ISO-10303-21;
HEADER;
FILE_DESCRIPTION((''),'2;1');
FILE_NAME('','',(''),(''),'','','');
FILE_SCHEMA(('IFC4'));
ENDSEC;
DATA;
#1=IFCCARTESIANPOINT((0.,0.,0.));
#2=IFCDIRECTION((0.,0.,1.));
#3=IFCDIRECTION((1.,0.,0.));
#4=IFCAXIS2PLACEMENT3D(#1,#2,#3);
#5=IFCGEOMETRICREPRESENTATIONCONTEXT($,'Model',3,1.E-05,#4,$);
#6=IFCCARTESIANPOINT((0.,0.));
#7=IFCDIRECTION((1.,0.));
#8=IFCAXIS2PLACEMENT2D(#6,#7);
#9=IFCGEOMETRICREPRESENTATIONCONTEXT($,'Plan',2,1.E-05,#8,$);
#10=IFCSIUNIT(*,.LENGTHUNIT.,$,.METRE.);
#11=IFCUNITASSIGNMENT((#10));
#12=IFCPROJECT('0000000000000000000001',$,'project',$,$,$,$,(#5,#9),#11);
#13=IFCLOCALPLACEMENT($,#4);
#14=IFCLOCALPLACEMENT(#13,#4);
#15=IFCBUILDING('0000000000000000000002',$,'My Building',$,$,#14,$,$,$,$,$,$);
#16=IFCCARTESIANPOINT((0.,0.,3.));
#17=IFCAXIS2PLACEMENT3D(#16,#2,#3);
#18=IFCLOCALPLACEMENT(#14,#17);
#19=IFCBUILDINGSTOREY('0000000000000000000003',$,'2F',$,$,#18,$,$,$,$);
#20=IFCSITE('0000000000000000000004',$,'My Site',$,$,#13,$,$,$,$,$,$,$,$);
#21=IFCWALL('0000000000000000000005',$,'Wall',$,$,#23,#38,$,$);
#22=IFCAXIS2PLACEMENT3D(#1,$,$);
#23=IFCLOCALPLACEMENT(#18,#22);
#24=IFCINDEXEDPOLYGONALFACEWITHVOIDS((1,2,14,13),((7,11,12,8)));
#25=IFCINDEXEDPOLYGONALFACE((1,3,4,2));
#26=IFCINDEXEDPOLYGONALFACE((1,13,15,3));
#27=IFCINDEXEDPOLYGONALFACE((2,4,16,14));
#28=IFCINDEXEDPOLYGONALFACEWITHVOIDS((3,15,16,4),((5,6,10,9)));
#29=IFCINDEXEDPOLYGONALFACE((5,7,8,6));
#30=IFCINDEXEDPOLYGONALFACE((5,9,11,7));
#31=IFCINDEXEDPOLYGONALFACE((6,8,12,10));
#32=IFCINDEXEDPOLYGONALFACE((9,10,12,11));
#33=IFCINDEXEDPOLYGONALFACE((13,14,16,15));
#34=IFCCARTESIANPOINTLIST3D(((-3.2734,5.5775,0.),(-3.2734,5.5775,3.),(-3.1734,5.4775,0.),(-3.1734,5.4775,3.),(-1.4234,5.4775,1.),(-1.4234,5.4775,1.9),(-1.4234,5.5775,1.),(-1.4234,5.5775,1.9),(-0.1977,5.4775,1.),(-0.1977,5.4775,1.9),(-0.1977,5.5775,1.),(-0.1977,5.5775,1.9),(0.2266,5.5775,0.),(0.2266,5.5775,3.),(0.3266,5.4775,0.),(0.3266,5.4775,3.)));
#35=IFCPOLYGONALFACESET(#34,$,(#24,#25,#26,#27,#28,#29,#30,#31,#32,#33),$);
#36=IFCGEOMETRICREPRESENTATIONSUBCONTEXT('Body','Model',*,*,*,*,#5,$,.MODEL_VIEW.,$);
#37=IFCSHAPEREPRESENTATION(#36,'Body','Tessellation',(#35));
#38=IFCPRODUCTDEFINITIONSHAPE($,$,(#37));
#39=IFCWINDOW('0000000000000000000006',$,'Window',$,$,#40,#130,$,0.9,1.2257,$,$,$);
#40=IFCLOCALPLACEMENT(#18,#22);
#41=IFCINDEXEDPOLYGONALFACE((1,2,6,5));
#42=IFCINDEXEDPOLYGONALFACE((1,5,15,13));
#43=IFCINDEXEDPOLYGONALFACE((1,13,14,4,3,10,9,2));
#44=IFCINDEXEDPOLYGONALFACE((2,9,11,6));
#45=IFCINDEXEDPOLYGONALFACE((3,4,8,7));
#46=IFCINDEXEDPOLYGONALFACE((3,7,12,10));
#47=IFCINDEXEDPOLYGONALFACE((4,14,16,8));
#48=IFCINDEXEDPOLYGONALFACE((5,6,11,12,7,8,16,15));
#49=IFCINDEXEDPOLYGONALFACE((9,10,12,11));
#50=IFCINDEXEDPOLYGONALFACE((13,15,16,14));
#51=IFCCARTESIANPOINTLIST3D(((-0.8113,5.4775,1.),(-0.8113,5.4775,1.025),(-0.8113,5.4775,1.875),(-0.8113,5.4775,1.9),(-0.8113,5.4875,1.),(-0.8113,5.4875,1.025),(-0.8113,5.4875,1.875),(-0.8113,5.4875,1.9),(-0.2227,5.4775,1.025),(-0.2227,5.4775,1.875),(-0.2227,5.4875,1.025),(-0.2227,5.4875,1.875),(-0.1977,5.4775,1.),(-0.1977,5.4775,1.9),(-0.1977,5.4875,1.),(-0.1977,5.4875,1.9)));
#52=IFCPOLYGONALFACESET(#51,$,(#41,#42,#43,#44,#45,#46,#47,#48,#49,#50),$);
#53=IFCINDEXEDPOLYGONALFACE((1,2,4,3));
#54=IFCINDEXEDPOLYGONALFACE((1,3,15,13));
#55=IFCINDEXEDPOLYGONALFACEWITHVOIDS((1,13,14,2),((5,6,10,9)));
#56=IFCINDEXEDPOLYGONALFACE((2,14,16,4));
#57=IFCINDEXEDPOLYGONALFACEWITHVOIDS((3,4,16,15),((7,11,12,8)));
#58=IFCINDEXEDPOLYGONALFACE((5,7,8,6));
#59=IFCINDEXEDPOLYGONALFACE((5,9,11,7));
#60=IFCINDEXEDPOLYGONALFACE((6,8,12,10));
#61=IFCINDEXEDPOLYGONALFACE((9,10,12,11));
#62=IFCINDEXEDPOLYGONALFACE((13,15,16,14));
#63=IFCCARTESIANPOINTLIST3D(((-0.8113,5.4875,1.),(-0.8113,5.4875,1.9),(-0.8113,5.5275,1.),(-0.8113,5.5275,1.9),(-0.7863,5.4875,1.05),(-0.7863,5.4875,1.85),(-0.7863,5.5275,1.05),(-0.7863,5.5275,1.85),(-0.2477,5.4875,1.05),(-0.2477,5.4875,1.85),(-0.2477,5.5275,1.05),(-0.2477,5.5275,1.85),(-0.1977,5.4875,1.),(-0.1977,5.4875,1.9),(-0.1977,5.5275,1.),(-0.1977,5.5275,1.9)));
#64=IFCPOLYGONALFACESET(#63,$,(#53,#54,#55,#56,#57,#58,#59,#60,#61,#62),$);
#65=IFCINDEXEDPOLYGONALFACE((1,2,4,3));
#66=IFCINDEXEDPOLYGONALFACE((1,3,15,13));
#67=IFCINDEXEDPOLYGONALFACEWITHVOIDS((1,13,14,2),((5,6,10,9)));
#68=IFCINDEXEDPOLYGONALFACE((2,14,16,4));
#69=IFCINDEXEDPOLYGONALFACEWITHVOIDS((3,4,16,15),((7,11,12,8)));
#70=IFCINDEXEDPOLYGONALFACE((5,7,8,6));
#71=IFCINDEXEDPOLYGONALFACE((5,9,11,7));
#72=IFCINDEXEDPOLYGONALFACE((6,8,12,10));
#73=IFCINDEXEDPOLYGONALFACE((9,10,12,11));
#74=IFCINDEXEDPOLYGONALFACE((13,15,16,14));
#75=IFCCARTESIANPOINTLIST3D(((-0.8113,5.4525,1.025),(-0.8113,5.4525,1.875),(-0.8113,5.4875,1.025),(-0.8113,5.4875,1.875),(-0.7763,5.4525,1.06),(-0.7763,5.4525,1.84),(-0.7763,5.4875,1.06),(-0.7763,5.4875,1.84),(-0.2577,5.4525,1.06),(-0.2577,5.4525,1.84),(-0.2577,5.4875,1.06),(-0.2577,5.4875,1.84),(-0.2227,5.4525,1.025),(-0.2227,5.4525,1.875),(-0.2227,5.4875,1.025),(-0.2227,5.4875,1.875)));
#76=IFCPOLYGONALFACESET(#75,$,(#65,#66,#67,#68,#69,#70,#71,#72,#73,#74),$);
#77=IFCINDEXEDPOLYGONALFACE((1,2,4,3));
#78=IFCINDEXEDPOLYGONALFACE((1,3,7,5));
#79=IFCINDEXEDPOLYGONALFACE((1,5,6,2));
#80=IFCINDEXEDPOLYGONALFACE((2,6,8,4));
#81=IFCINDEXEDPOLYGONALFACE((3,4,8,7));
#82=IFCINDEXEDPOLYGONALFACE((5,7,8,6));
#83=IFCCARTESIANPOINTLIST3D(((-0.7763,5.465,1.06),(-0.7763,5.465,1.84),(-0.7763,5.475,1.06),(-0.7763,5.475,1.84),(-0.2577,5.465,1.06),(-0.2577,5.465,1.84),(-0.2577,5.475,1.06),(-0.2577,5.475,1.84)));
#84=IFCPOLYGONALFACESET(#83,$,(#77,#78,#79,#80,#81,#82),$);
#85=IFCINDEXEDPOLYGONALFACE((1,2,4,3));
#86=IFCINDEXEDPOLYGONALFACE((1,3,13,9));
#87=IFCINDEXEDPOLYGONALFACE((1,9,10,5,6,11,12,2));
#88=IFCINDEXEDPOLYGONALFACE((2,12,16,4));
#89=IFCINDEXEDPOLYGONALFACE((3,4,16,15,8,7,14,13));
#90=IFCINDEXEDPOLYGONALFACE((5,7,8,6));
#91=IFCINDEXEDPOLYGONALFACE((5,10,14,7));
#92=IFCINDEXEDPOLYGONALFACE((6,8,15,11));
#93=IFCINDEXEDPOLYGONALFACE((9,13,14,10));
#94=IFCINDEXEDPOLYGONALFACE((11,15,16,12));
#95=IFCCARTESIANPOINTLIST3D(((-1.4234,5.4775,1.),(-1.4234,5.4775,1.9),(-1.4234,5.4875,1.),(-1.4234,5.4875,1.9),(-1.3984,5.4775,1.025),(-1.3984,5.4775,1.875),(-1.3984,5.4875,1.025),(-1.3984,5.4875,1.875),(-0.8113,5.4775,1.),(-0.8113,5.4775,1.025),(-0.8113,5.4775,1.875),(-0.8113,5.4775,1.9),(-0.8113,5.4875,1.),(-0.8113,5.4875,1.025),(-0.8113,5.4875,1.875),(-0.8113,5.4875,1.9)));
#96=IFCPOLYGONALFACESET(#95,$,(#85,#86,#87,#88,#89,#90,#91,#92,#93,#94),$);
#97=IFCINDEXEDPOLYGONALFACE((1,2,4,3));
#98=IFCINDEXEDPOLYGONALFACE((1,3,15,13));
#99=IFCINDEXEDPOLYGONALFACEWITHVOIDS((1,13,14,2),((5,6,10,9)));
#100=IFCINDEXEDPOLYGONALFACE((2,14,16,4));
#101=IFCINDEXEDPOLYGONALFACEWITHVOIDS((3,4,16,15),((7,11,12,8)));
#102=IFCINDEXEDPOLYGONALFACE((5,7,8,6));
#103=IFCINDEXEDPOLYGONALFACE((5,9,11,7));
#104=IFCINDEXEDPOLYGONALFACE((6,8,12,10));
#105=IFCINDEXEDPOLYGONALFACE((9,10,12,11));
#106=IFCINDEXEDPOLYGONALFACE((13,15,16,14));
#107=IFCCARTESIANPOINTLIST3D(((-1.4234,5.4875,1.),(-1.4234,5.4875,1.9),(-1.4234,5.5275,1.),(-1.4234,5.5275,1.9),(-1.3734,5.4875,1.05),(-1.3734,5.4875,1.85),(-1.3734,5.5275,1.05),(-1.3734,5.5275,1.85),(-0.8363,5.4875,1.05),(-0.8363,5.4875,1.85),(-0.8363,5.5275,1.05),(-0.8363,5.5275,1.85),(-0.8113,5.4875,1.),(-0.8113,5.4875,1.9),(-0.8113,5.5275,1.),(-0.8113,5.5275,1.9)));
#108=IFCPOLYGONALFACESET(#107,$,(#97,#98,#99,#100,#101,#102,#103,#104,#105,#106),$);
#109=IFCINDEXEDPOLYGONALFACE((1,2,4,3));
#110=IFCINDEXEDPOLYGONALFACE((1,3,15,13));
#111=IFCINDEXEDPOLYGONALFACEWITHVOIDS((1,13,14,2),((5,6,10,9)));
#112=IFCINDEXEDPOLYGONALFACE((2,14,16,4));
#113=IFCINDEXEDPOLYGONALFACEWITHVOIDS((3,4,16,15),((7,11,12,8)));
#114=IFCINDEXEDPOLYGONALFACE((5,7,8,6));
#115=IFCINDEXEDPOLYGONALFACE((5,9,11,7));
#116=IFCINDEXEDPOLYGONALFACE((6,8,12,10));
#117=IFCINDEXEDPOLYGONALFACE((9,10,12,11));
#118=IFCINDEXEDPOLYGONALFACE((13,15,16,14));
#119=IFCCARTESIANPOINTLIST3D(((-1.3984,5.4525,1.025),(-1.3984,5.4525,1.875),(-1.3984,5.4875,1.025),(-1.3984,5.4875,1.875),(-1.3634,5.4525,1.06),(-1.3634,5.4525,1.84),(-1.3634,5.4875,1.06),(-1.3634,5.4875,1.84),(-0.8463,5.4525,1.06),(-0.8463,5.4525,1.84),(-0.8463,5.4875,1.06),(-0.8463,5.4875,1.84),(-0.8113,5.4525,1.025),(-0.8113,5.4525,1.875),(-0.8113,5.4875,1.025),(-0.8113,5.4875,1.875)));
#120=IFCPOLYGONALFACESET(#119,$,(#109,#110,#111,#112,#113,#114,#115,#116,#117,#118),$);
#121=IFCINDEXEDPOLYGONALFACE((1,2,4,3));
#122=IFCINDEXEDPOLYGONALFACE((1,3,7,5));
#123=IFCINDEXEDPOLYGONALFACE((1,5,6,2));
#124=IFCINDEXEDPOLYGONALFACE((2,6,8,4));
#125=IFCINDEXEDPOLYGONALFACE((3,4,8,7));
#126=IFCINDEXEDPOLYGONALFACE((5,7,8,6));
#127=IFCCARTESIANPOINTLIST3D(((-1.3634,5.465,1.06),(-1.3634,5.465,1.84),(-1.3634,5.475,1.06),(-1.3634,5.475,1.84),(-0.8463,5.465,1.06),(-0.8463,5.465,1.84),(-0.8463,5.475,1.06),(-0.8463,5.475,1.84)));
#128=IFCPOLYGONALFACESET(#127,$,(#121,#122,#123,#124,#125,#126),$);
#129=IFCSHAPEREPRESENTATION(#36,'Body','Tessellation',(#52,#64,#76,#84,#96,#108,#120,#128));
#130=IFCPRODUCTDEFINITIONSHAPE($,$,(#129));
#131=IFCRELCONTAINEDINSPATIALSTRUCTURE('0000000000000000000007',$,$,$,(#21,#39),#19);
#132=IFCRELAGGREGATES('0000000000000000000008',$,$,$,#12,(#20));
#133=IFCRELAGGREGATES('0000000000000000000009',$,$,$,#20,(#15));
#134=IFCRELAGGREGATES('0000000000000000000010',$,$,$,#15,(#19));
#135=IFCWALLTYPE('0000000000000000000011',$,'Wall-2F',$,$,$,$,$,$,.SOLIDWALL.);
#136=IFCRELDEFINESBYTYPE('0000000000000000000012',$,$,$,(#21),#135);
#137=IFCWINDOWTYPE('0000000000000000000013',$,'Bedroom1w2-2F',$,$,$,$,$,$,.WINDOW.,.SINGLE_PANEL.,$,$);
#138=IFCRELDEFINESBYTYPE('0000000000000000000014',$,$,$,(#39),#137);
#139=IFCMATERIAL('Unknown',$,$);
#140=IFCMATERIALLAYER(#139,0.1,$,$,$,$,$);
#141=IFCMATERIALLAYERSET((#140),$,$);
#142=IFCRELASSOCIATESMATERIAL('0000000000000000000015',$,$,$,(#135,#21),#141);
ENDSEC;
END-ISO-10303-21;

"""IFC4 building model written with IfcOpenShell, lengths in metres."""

from ifc_helpers import new_model, entity, si_unit, frame, origin_with_axes, origin_2d_with_axis, place, context, subcontext, project, spatial, line, indexed_curve, outline, extrude, shape, source, transform, mapped, material, layer, layer_set, layer_usage, type_object, type_shapes, element, fill, save


model = new_model("IFC4")

# Units and contexts
model_context = context("Model", 3, precision=1e-05, world=origin_with_axes())
plan_context = context("Plan", 2, precision=1e-05, world=origin_2d_with_axis())
body_context_1 = subcontext(model_context, "Body", "Model", "MODEL_VIEW")
body_context_2 = subcontext(plan_context, "Body", "Plan", "PLAN_VIEW")
ifc_project = project(units=[si_unit("LENGTHUNIT", "METRE")], contexts=[model_context, plan_context])

# Site, building, storey
site_placement = place(None, origin_with_axes())
site = spatial("IfcSite", under=ifc_project, at=site_placement, Name="My Site")
building_placement = place(site_placement, origin_with_axes())
building = spatial("IfcBuilding", under=site, at=building_placement, Name="My Building")
storey_placement = place(building_placement, frame((0.0, 0.0, 3.0), z_axis=(0.0, 0.0, 1.0), x_axis=(1.0, 0.0, 0.0)))
storey = spatial("IfcBuildingStorey", under=building, at=storey_placement, Name="2F")

# Shared definitions
ifc_material = material(Name="Unknown")

# Shared definitions
ifc_layer_1 = layer(ifc_material, 0.1)
ifc_layer_set_1 = layer_set([ifc_layer_1])
wall_type_1 = type_object("IfcWallType", Name="Wall-2F", PredefinedType="SOLIDWALL", material=ifc_layer_set_1)

# Wall, opening, window
ifc_layer_usage_1 = layer_usage(ifc_layer_set_1, "AXIS2", "POSITIVE", 0.0)
wall_1_placement = place(storey_placement, frame((0.2266, 5.5775, 0.0), z_axis=(0.0, 0.0, 1.0), x_axis=(-1.0, 0.0, 0.0)))
wall_1 = element("IfcWall", 1, at=wall_1_placement, inside=storey, type_object=wall_type_1, material=ifc_layer_usage_1, Name="Wall", context=body_context_1, shape_type="SweptSolid", body=[
    extrude(outline(indexed_curve([(0.0, 0.0), (-0.1, 0.1), (3.4, 0.1), (3.5, 0.0)], segments=[line(1, 2, 3, 4, 1)])), origin_with_axes(), (0.0, 0.0, 1.0), 3.0),
])
shared_shape_1 = source(origin_with_axes(), body_context_1, "Body", "SweptSolid", [
    extrude(outline(indexed_curve([(0.0, 0.0), (1.2257, 0.0), (1.2257, 0.9), (0.0, 0.9)], segments=[line(1, 2, 3, 4, 1)])), frame((0.0, -0.6, 0.0), z_axis=(0.0, -1.0, 0.0), x_axis=(1.0, 0.0, 0.0)), (0.0, 0.0, -1.0), 1.2),
])
opening_1_placement = place(wall_1_placement, frame((0.4243, 0.0, 1.0), z_axis=(0.0, 0.0, 1.0), x_axis=(1.0, 0.0, 0.0)))
opening_1 = element("IfcOpeningElement", 2, at=opening_1_placement, cuts=wall_1, PredefinedType="OPENING", context=body_context_1, shape_type="MappedRepresentation", body=[
    mapped(shared_shape_1, transform((0.0, 0.0, 0.0), x_axis=(1.0, 0.0, 0.0), y_axis=(0.0, 1.0, 0.0), z_axis=(0.0, 0.0, 1.0), scale=1.0)),
])
window_type_1 = type_object("IfcWindowType", Name="Bedroom1w2-2F", PartitioningType="SINGLE_PANEL", PredefinedType="WINDOW")
shared_shape_2 = source(origin_with_axes(), body_context_1, "Body", "SweptSolid", [
    extrude(outline(indexed_curve([(0.6136, 0.0), (0.0, 0.0), (0.0, 0.9), (0.6136, 0.9), (0.6136, 0.875), (0.025, 0.875), (0.025, 0.025), (0.6136, 0.025)], segments=[line(1, 2, 3, 4, 5, 6, 7, 8, 1)])), frame((0.0, 0.09, 0.0), z_axis=(0.0, -1.0, 0.0), x_axis=(1.0, 0.0, 0.0)), (0.0, 0.0, -1.0), 0.01),
    extrude(outline(indexed_curve([(0.0, 0.0), (0.6136, 0.0), (0.6136, 0.9), (0.0, 0.9)], segments=[line(1, 2, 3, 4, 1)]), holes=[indexed_curve([(0.05, 0.05), (0.5886, 0.05), (0.5886, 0.85), (0.05, 0.85)], segments=[line(1, 2, 3, 4, 1)])]), frame((0.0, 0.05, 0.0), z_axis=(0.0, -1.0, 0.0), x_axis=(1.0, 0.0, 0.0)), (0.0, 0.0, -1.0), 0.04),
    extrude(outline(indexed_curve([(0.0, 0.0), (0.5886, 0.0), (0.5886, 0.85), (0.0, 0.85)], segments=[line(1, 2, 3, 4, 1)]), holes=[indexed_curve([(0.035, 0.035), (0.5536, 0.035), (0.5536, 0.815), (0.035, 0.815)], segments=[line(1, 2, 3, 4, 1)])]), frame((0.025, 0.09, 0.025), z_axis=(0.0, -1.0, 0.0), x_axis=(1.0, 0.0, 0.0)), (0.0, 0.0, -1.0), 0.035),
    extrude(outline(indexed_curve([(0.035, 0.035), (0.5536, 0.035), (0.5536, 0.815), (0.035, 0.815)], segments=[line(1, 2, 3, 4, 1)])), frame((0.025, 0.1025, 0.025), z_axis=(0.0, -1.0, 0.0), x_axis=(1.0, 0.0, 0.0)), (0.0, 0.0, -1.0), 0.01),
    extrude(outline(indexed_curve([(0.0, 0.9), (0.6121, 0.9), (0.6121, 0.0), (0.0, 0.0), (0.0, 0.025), (0.5871, 0.025), (0.5871, 0.875), (0.0, 0.875)], segments=[line(1, 2, 3, 4, 5, 6, 7, 8, 1)])), frame((0.6136, 0.09, 0.0), z_axis=(0.0, -1.0, 0.0), x_axis=(1.0, 0.0, 0.0)), (0.0, 0.0, -1.0), 0.01),
    extrude(outline(indexed_curve([(0.0, 0.0), (0.6121, 0.0), (0.6121, 0.9), (0.0, 0.9)], segments=[line(1, 2, 3, 4, 1)]), holes=[indexed_curve([(0.025, 0.05), (0.5621, 0.05), (0.5621, 0.85), (0.025, 0.85)], segments=[line(1, 2, 3, 4, 1)])]), frame((0.6136, 0.05, 0.0), z_axis=(0.0, -1.0, 0.0), x_axis=(1.0, 0.0, 0.0)), (0.0, 0.0, -1.0), 0.04),
    extrude(outline(indexed_curve([(0.0, 0.0), (0.5871, 0.0), (0.5871, 0.85), (0.0, 0.85)], segments=[line(1, 2, 3, 4, 1)]), holes=[indexed_curve([(0.035, 0.035), (0.5521, 0.035), (0.5521, 0.815), (0.035, 0.815)], segments=[line(1, 2, 3, 4, 1)])]), frame((0.6136, 0.09, 0.025), z_axis=(0.0, -1.0, 0.0), x_axis=(1.0, 0.0, 0.0)), (0.0, 0.0, -1.0), 0.035),
    extrude(outline(indexed_curve([(0.035, 0.035), (0.5521, 0.035), (0.5521, 0.815), (0.035, 0.815)], segments=[line(1, 2, 3, 4, 1)])), frame((0.6136, 0.1025, 0.025), z_axis=(0.0, -1.0, 0.0), x_axis=(1.0, 0.0, 0.0)), (0.0, 0.0, -1.0), 0.01),
])
shared_shape_3 = source(origin_with_axes(), body_context_2, "Body", "Curve2D", [
    entity("IfcIndexedPolyCurve", entity("IfcCartesianPointList2D", [[0.05, 0.05], [0.5886, 0.05]])),
    entity("IfcIndexedPolyCurve", entity("IfcCartesianPointList2D", [[0.0, 0.1], [0.025, 0.1], [0.025, 0.09], [0.05, 0.09], [0.05, 0.05], [0.0, 0.05]]), [entity("IfcLineIndex", [1, 2, 3, 4, 5, 6, 1])]),
    entity("IfcIndexedPolyCurve", entity("IfcCartesianPointList2D", [[0.6136, 0.1], [0.6136, 0.1], [0.6136, 0.09], [0.5886, 0.09], [0.5886, 0.05], [0.6136, 0.05]])),
    entity("IfcIndexedPolyCurve", entity("IfcCartesianPointList2D", [[0.025, 0.09], [0.06, 0.09], [0.06, 0.125], [0.025, 0.125]]), [entity("IfcLineIndex", [1, 2, 3, 4, 1])]),
    entity("IfcIndexedPolyCurve", entity("IfcCartesianPointList2D", [[0.6136, 0.09], [0.5786, 0.09], [0.5786, 0.125], [0.6136, 0.125]]), [entity("IfcLineIndex", [1, 2, 3, 4, 1])]),
    entity("IfcIndexedPolyCurve", entity("IfcCartesianPointList2D", [[0.06, 0.09], [0.5786, 0.09]])),
    entity("IfcIndexedPolyCurve", entity("IfcCartesianPointList2D", [[0.06, 0.125], [0.5786, 0.125]])),
    entity("IfcIndexedPolyCurve", entity("IfcCartesianPointList2D", [[0.06, 0.1075], [0.5786, 0.1075]])),
    entity("IfcIndexedPolyCurve", entity("IfcCartesianPointList2D", [[0.6386, 0.05], [1.1757, 0.05]])),
    entity("IfcIndexedPolyCurve", entity("IfcCartesianPointList2D", [[0.6136, 0.1], [0.6136, 0.1], [0.6136, 0.09], [0.6386, 0.09], [0.6386, 0.05], [0.6136, 0.05]])),
    entity("IfcIndexedPolyCurve", entity("IfcCartesianPointList2D", [[1.2257, 0.1], [1.2007, 0.1], [1.2007, 0.09], [1.1757, 0.09], [1.1757, 0.05], [1.2257, 0.05]]), [entity("IfcLineIndex", [1, 2, 3, 4, 5, 6, 1])]),
    entity("IfcIndexedPolyCurve", entity("IfcCartesianPointList2D", [[0.6136, 0.09], [0.6486, 0.09], [0.6486, 0.125], [0.6136, 0.125]]), [entity("IfcLineIndex", [1, 2, 3, 4, 1])]),
    entity("IfcIndexedPolyCurve", entity("IfcCartesianPointList2D", [[1.2007, 0.09], [1.1657, 0.09], [1.1657, 0.125], [1.2007, 0.125]]), [entity("IfcLineIndex", [1, 2, 3, 4, 1])]),
    entity("IfcIndexedPolyCurve", entity("IfcCartesianPointList2D", [[0.6486, 0.09], [1.1657, 0.09]])),
    entity("IfcIndexedPolyCurve", entity("IfcCartesianPointList2D", [[0.6486, 0.125], [1.1657, 0.125]])),
    entity("IfcIndexedPolyCurve", entity("IfcCartesianPointList2D", [[0.6486, 0.1075], [1.1657, 0.1075]])),
])
type_shapes(window_type_1, [shared_shape_2, shared_shape_3])
window_1_placement = place(opening_1_placement, frame((0.0, 0.0, 0.0), z_axis=(0.0, 0.0, 1.0), x_axis=(1.0, 0.0, 0.0)))
window_1 = element("IfcWindow", 3, at=window_1_placement, inside=storey, type_object=window_type_1, Name="Window", OverallHeight=0.9, OverallWidth=1.2257, shapes=[
    shape(body_context_1, "Body", "MappedRepresentation", [mapped(shared_shape_2, transform((0.0, 0.0, 0.0), x_axis=(1.0, 0.0, 0.0), y_axis=(0.0, 1.0, 0.0), z_axis=(0.0, 0.0, 1.0), scale=1.0))]),
    shape(body_context_2, "Body", "MappedRepresentation", [mapped(shared_shape_3, transform((0.0, 0.0, 0.0), x_axis=(1.0, 0.0, 0.0), y_axis=(0.0, 1.0, 0.0), z_axis=(0.0, 0.0, 1.0), scale=1.0))]),
])
fill(opening_1, window_1)

save(model, "model.ifc")
